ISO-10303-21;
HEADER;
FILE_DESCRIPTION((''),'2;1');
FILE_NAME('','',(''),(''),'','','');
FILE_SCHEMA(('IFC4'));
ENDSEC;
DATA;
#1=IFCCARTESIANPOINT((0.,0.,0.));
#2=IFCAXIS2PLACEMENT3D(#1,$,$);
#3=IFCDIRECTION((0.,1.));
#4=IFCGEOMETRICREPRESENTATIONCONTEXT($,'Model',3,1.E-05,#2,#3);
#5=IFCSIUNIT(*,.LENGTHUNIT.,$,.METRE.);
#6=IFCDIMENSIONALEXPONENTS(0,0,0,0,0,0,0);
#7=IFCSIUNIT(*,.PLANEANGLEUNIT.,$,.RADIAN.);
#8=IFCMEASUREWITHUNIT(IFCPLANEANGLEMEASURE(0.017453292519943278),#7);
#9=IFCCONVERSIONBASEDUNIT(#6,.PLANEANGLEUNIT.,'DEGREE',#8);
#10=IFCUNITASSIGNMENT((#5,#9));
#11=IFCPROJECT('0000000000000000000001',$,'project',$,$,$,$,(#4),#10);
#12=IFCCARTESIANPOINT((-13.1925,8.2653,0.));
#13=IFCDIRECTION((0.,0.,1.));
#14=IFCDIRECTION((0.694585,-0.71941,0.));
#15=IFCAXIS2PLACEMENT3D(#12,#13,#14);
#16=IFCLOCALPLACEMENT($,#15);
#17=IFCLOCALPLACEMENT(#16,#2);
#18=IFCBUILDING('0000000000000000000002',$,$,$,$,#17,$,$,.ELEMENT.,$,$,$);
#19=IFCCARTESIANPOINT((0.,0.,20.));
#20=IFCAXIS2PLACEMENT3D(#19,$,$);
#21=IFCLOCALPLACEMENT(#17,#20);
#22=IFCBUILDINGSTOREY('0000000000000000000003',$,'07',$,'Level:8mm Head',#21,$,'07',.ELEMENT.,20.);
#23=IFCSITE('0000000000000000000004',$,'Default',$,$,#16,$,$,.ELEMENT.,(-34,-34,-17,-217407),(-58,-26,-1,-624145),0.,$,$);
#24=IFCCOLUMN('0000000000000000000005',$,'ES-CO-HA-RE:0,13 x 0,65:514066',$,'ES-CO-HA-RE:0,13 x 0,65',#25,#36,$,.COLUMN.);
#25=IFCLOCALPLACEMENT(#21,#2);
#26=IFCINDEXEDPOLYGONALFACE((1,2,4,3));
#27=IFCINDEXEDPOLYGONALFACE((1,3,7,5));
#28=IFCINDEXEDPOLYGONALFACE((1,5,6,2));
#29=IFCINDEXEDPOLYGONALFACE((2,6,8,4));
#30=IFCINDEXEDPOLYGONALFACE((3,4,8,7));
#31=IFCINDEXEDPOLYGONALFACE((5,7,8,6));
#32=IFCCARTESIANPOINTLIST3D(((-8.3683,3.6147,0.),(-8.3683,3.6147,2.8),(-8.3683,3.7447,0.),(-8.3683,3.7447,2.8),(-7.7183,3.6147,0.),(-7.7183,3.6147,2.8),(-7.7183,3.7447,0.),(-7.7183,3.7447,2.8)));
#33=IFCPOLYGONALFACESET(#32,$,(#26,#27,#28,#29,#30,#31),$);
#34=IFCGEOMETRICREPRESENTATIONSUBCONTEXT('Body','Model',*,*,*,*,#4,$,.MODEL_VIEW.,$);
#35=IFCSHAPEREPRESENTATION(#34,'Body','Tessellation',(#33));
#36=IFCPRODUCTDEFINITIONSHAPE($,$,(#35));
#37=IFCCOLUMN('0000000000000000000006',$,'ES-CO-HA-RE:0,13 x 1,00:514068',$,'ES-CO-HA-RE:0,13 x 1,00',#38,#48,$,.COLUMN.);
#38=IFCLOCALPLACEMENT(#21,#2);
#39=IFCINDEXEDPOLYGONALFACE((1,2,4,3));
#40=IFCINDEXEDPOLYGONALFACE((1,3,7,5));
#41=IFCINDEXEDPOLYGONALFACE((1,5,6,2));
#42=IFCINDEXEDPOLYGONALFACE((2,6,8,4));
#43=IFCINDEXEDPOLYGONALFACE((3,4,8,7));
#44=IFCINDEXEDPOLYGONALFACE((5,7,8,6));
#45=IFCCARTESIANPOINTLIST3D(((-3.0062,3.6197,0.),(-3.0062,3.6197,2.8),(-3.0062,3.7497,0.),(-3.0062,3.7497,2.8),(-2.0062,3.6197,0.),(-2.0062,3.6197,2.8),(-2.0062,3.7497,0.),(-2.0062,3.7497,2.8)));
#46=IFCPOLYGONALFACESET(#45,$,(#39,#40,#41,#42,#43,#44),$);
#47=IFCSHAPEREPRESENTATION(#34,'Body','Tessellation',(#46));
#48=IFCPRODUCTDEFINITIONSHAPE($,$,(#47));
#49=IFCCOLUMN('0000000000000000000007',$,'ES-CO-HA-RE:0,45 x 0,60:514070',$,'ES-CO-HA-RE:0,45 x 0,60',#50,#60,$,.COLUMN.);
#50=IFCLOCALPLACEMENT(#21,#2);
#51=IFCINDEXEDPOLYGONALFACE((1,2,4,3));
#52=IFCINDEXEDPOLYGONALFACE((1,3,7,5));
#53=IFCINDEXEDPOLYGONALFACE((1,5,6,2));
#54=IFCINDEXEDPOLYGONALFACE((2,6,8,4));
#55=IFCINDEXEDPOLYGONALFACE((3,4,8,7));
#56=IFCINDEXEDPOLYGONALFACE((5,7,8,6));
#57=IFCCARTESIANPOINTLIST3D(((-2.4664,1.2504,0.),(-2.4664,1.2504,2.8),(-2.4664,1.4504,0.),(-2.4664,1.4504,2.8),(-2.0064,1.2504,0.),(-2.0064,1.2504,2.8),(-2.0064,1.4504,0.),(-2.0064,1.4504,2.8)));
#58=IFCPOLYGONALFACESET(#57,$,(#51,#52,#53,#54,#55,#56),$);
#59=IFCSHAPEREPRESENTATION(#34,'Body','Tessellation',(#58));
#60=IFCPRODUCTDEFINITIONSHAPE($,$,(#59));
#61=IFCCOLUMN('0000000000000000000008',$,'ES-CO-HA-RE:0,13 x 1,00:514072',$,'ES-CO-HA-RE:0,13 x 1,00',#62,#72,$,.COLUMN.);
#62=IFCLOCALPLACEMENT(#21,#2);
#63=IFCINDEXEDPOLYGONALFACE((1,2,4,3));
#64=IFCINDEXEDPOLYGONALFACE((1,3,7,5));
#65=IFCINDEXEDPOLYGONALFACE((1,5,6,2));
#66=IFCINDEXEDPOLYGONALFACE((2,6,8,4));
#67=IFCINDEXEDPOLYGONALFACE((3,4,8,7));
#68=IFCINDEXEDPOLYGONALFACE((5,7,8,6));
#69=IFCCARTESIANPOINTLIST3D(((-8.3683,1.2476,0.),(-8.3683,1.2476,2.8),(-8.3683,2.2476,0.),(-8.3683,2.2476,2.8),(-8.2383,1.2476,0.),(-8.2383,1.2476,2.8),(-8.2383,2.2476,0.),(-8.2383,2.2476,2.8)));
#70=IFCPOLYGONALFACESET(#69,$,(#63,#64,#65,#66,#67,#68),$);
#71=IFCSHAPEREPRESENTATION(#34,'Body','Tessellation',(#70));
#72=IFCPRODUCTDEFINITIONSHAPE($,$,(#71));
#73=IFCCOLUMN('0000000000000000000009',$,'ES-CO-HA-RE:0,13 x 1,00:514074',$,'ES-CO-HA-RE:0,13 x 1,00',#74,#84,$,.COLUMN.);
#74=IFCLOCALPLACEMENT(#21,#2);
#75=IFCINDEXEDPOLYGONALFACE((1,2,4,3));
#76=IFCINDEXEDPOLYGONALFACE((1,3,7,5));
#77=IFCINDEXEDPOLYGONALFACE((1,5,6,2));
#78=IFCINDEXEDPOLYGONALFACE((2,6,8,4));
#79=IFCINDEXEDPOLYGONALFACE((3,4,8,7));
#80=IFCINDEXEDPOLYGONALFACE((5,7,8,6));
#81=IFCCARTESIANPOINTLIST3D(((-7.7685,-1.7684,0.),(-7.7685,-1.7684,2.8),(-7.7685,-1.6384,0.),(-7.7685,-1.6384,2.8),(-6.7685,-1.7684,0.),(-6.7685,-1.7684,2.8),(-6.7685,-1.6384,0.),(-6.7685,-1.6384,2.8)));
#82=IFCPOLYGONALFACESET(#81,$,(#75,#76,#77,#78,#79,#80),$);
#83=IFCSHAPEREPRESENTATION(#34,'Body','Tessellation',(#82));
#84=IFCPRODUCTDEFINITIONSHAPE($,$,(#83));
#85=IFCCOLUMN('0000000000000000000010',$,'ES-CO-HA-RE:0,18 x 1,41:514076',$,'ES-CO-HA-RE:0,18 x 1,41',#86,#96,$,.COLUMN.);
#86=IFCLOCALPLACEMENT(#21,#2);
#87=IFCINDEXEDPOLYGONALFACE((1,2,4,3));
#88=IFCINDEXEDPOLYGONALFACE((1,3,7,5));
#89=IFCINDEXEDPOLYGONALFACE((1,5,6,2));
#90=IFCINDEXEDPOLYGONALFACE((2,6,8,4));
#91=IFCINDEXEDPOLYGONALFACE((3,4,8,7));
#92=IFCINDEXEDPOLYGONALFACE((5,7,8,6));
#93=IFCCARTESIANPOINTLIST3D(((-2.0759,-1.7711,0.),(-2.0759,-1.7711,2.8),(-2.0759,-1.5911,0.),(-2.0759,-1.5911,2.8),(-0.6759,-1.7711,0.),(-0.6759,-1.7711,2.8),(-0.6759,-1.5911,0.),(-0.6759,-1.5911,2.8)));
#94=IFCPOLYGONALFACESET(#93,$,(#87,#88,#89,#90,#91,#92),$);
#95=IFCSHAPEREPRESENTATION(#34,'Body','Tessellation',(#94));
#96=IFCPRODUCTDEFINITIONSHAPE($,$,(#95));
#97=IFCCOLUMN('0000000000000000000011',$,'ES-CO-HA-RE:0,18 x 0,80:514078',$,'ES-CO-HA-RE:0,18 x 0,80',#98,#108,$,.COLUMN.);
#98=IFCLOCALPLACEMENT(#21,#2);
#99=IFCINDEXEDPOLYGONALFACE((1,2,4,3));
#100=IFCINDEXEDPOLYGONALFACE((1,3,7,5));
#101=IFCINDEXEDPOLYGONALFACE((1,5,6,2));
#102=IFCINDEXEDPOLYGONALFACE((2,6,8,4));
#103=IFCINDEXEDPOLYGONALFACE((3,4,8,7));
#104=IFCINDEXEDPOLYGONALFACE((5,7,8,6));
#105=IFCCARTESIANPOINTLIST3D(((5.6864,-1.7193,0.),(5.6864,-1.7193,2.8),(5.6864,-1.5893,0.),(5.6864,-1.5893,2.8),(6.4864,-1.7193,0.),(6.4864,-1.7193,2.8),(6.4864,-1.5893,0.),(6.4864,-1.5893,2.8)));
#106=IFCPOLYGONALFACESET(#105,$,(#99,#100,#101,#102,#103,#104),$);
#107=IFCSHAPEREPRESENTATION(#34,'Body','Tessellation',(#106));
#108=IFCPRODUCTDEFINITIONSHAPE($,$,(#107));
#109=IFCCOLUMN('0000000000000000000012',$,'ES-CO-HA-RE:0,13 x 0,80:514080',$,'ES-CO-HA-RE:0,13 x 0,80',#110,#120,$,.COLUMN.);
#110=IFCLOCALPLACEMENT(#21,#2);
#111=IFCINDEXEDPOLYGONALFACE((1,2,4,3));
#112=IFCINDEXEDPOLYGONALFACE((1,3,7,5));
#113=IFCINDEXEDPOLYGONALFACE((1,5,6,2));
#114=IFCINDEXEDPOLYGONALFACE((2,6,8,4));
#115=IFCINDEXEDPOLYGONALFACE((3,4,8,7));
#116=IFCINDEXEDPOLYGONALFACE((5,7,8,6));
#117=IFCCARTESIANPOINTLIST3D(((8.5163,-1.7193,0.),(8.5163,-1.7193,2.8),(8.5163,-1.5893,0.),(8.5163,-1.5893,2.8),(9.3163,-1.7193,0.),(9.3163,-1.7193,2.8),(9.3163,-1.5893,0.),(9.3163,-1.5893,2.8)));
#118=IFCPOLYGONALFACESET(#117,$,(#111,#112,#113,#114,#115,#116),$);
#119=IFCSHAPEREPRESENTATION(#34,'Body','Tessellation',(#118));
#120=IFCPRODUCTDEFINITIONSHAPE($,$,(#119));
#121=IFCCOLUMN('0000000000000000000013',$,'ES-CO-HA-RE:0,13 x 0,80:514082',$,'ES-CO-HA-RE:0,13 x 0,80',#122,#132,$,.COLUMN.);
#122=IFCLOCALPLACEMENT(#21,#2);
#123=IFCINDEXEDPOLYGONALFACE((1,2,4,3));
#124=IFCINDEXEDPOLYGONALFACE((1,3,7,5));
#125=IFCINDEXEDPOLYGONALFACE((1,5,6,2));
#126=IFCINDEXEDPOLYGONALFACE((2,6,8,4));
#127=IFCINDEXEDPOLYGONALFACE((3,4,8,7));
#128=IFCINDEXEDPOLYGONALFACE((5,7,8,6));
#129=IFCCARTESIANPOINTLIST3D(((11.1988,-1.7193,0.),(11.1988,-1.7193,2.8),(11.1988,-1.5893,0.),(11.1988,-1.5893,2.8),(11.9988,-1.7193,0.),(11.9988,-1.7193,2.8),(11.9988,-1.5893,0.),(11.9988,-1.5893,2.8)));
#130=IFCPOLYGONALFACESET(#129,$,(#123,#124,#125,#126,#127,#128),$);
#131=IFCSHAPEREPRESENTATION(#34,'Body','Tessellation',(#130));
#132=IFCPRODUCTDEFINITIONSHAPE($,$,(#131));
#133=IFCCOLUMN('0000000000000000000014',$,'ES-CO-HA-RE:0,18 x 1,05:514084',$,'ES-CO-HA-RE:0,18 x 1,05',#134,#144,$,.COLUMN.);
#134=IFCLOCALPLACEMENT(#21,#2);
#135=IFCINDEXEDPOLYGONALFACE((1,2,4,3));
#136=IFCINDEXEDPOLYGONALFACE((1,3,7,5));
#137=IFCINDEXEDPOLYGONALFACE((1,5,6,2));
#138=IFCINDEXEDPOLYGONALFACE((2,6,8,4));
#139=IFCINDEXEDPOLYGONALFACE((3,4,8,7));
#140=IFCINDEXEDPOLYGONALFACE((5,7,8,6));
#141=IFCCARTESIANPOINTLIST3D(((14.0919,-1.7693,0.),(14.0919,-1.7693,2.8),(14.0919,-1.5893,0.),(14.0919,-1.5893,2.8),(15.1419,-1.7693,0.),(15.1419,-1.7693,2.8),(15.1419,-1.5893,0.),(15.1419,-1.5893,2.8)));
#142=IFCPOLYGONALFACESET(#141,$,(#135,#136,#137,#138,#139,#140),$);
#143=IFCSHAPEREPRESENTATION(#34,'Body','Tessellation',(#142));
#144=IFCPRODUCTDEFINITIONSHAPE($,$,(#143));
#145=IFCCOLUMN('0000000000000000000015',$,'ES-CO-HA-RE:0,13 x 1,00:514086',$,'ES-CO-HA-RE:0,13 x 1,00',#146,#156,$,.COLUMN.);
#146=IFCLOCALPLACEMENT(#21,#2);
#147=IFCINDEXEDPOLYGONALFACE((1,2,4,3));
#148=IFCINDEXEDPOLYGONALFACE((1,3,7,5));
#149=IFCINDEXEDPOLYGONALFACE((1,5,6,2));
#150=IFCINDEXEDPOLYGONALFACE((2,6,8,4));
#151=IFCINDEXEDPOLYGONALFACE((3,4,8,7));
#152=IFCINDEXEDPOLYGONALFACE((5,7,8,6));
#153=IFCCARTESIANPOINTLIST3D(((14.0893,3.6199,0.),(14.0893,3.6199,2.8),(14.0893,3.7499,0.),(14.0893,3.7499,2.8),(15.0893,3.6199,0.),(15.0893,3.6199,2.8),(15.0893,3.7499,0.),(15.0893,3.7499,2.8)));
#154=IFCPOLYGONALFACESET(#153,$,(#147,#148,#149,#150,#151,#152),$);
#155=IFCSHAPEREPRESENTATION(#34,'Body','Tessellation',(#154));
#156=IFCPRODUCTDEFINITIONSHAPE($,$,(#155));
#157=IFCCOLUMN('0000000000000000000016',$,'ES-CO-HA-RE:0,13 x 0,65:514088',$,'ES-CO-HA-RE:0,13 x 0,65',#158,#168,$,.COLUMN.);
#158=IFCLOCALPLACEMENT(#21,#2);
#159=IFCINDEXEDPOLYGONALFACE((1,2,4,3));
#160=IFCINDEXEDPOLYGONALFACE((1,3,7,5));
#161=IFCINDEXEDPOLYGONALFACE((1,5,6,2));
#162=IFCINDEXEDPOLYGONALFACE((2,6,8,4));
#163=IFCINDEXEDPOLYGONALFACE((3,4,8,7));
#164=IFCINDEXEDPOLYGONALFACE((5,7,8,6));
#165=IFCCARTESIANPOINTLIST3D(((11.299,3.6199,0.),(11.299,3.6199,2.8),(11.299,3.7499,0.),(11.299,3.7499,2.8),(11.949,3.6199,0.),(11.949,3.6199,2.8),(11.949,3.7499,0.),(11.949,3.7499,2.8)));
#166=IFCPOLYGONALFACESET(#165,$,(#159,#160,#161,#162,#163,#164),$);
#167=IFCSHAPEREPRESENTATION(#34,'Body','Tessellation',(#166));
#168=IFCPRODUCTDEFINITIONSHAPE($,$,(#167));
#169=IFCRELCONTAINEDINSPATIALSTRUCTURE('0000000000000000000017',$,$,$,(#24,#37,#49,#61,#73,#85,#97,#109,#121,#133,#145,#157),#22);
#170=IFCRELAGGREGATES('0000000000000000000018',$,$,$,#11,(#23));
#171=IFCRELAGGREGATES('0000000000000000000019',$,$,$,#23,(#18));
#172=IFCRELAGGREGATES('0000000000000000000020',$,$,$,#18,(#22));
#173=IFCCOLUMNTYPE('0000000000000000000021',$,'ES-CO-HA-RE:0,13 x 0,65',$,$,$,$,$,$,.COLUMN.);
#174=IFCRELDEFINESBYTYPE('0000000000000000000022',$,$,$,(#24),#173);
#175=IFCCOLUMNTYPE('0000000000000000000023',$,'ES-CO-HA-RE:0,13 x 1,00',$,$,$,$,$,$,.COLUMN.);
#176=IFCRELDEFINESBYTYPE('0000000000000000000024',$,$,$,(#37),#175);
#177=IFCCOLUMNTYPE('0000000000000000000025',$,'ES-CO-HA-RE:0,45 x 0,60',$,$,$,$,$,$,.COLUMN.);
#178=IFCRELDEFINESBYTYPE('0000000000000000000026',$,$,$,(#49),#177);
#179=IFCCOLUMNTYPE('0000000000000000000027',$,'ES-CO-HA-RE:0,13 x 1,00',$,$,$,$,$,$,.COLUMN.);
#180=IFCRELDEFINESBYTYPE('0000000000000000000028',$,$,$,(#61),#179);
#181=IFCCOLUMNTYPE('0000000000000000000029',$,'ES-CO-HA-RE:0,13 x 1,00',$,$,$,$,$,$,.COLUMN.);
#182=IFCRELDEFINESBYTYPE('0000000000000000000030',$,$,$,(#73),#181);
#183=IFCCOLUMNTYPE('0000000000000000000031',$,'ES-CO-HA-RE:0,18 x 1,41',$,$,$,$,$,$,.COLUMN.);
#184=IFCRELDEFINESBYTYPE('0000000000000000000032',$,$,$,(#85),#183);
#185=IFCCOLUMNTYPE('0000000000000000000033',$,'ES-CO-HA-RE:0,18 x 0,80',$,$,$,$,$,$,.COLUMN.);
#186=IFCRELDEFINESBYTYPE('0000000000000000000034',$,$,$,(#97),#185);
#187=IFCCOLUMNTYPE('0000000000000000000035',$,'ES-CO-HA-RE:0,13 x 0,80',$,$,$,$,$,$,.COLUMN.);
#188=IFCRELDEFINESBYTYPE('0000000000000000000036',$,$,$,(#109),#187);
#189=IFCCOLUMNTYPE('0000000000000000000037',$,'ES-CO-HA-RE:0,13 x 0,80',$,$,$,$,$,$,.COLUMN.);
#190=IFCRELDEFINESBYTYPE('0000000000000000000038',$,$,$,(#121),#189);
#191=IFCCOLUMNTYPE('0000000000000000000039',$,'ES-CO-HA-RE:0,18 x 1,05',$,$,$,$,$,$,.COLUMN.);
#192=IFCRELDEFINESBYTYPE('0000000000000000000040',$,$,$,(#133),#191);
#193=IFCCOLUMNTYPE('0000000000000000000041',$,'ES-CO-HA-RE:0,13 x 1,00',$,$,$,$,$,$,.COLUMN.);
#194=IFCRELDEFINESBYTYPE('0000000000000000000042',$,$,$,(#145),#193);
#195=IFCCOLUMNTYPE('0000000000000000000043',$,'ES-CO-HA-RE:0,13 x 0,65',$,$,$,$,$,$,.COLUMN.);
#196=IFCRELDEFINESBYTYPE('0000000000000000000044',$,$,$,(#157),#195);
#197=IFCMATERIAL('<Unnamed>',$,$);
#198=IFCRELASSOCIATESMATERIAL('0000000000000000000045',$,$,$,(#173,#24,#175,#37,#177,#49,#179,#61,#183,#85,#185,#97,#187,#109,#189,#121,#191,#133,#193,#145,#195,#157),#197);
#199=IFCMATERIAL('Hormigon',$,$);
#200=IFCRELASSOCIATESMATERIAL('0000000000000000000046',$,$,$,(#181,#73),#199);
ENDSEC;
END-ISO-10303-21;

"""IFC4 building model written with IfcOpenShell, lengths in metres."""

from ifc_helpers import new_model, entity, si_unit, converted_unit, direction, frame, origin, place, context, subcontext, project, spatial, indexed_curve, outline, extrude, source, transform, mapped, material, type_object, type_shapes, element, save


model = new_model("IFC4")

# Units and contexts
model_context = context("Model", 3, precision=1e-05, world=origin(), true_north=direction((0.0, 1.0)))
body_context = subcontext(model_context, "Body", "Model", "MODEL_VIEW")
ifc_project = project(units=[si_unit("LENGTHUNIT", "METRE"), converted_unit("PLANEANGLEUNIT", "DEGREE", entity("IfcPlaneAngleMeasure", 0.017453292519943278), si_unit("PLANEANGLEUNIT", "RADIAN"), dimensions=[0, 0, 0, 0, 0, 0, 0])], contexts=[model_context])

# Site, building, storey
site_placement = place(None, frame((-13.1925, 8.2653, 0.0), z_axis=(0.0, 0.0, 1.0), x_axis=(0.694585, -0.71941, 0.0)))
site = spatial("IfcSite", under=ifc_project, at=site_placement, Name="Default", CompositionType="ELEMENT", RefLatitude=(-34, -34, -17, -217407), RefLongitude=(-58, -26, -1, -624145), RefElevation=0.0)
building_placement = place(site_placement, origin())
building = spatial("IfcBuilding", under=site, at=building_placement, CompositionType="ELEMENT")
storey_placement = place(building_placement, frame((0.0, 0.0, 20.0)))
storey = spatial("IfcBuildingStorey", under=building, at=storey_placement, Name="07", ObjectType="Level:8mm Head", LongName="07", CompositionType="ELEMENT", Elevation=20.0)

# Columns
ifc_material_1 = material(Name="<Unnamed>")
column_type_1 = type_object("IfcColumnType", Name="ES-CO-HA-RE:0,13 x 0,65", PredefinedType="COLUMN", material=ifc_material_1)
shared_shape_1 = source(origin(), body_context, "Body", "SweptSolid", [
    extrude(outline(indexed_curve([(-0.325, -0.065), (0.325, -0.065), (0.325, 0.065), (-0.325, 0.065), (-0.325, -0.065)], self_intersect=False)), frame((-8.0433, 3.6797, 20.0), z_axis=(0.0, 0.0, 1.0), x_axis=(-1.0, 0.0, 0.0)), (0.0, 0.0, 1.0), 2.8),
])
type_shapes(column_type_1, [shared_shape_1])
column_1_placement = place(storey_placement, frame((0.0, 0.0, -20.0)))
element("IfcColumn", 1, at=column_1_placement, inside=storey, type_object=column_type_1, material=ifc_material_1, Name="ES-CO-HA-RE:0,13 x 0,65:514066", ObjectType="ES-CO-HA-RE:0,13 x 0,65", PredefinedType="COLUMN", context=body_context, shape_type="MappedRepresentation", body=[
    mapped(shared_shape_1, transform((0.0, 0.0, 0.0), scale=1.0)),
])
column_type_2 = type_object("IfcColumnType", Name="ES-CO-HA-RE:0,13 x 1,00", PredefinedType="COLUMN", material=ifc_material_1)
shared_shape_2 = source(origin(), body_context, "Body", "SweptSolid", [
    extrude(outline(indexed_curve([(-0.5, -0.065), (0.5, -0.065), (0.5, 0.065), (-0.5, 0.065), (-0.5, -0.065)], self_intersect=False)), frame((-2.5062, 3.6847, 20.0), z_axis=(0.0, 0.0, 1.0), x_axis=(-1.0, 0.0, 0.0)), (0.0, 0.0, 1.0), 2.8),
])
type_shapes(column_type_2, [shared_shape_2])
column_2_placement = place(storey_placement, frame((0.0, 0.0, -20.0)))
element("IfcColumn", 2, at=column_2_placement, inside=storey, type_object=column_type_2, material=ifc_material_1, Name="ES-CO-HA-RE:0,13 x 1,00:514068", ObjectType="ES-CO-HA-RE:0,13 x 1,00", PredefinedType="COLUMN", context=body_context, shape_type="MappedRepresentation", body=[
    mapped(shared_shape_2, transform((0.0, 0.0, 0.0), scale=1.0)),
])
column_type_3 = type_object("IfcColumnType", Name="ES-CO-HA-RE:0,45 x 0,60", PredefinedType="COLUMN", material=ifc_material_1)
shared_shape_3 = source(origin(), body_context, "Body", "SweptSolid", [
    extrude(outline(indexed_curve([(-0.23, -0.1), (0.23, -0.1), (0.23, 0.1), (-0.23, 0.1), (-0.23, -0.1)], self_intersect=False)), frame((-2.2364, 1.3504, 20.0), z_axis=(0.0, 0.0, 1.0), x_axis=(-1.0, 0.0, 0.0)), (0.0, 0.0, 1.0), 2.8),
])
type_shapes(column_type_3, [shared_shape_3])
column_3_placement = place(storey_placement, frame((0.0, 0.0, -20.0)))
element("IfcColumn", 3, at=column_3_placement, inside=storey, type_object=column_type_3, material=ifc_material_1, Name="ES-CO-HA-RE:0,45 x 0,60:514070", ObjectType="ES-CO-HA-RE:0,45 x 0,60", PredefinedType="COLUMN", context=body_context, shape_type="MappedRepresentation", body=[
    mapped(shared_shape_3, transform((0.0, 0.0, 0.0), scale=1.0)),
])
column_type_4 = type_object("IfcColumnType", Name="ES-CO-HA-RE:0,13 x 1,00", PredefinedType="COLUMN", material=ifc_material_1)
shared_shape_4 = source(origin(), body_context, "Body", "SweptSolid", [
    extrude(outline(indexed_curve([(-0.5, -0.065), (0.5, -0.065), (0.5, 0.065), (-0.5, 0.065), (-0.5, -0.065)], self_intersect=False)), frame((-8.3033, 1.7476, 20.0), z_axis=(0.0, 0.0, 1.0), x_axis=(0.0, -1.0, 0.0)), (0.0, 0.0, 1.0), 2.8),
])
type_shapes(column_type_4, [shared_shape_4])
column_4_placement = place(storey_placement, frame((0.0, 0.0, -20.0)))
element("IfcColumn", 4, at=column_4_placement, inside=storey, type_object=column_type_4, material=ifc_material_1, Name="ES-CO-HA-RE:0,13 x 1,00:514072", ObjectType="ES-CO-HA-RE:0,13 x 1,00", PredefinedType="COLUMN", context=body_context, shape_type="MappedRepresentation", body=[
    mapped(shared_shape_4, transform((0.0, 0.0, 0.0), scale=1.0)),
])
ifc_material_2 = material(Name="Hormigon")
column_type_5 = type_object("IfcColumnType", Name="ES-CO-HA-RE:0,13 x 1,00", PredefinedType="COLUMN", material=ifc_material_2)
shared_shape_5 = source(origin(), body_context, "Body", "SweptSolid", [
    extrude(outline(indexed_curve([(-0.5, -0.065), (0.5, -0.065), (0.5, 0.065), (-0.5, 0.065), (-0.5, -0.065)], self_intersect=False)), frame((-7.2685, -1.7034, 20.0), z_axis=(0.0, 0.0, 1.0), x_axis=(-1.0, 0.0, 0.0)), (0.0, 0.0, 1.0), 2.8),
])
type_shapes(column_type_5, [shared_shape_5])
column_5_placement = place(storey_placement, frame((0.0, 0.0, -20.0)))
element("IfcColumn", 5, at=column_5_placement, inside=storey, type_object=column_type_5, material=ifc_material_2, Name="ES-CO-HA-RE:0,13 x 1,00:514074", ObjectType="ES-CO-HA-RE:0,13 x 1,00", PredefinedType="COLUMN", context=body_context, shape_type="MappedRepresentation", body=[
    mapped(shared_shape_5, transform((0.0, 0.0, 0.0), scale=1.0)),
])
column_type_6 = type_object("IfcColumnType", Name="ES-CO-HA-RE:0,18 x 1,41", PredefinedType="COLUMN", material=ifc_material_1)
shared_shape_6 = source(origin(), body_context, "Body", "SweptSolid", [
    extrude(outline(indexed_curve([(-0.7, -0.09), (0.7, -0.09), (0.7, 0.09), (-0.7, 0.09), (-0.7, -0.09)], self_intersect=False)), frame((-1.3759, -1.6811, 20.0), z_axis=(0.0, 0.0, 1.0), x_axis=(-1.0, 0.0, 0.0)), (0.0, 0.0, 1.0), 2.8),
])
type_shapes(column_type_6, [shared_shape_6])
column_6_placement = place(storey_placement, frame((0.0, 0.0, -20.0)))
element("IfcColumn", 6, at=column_6_placement, inside=storey, type_object=column_type_6, material=ifc_material_1, Name="ES-CO-HA-RE:0,18 x 1,41:514076", ObjectType="ES-CO-HA-RE:0,18 x 1,41", PredefinedType="COLUMN", context=body_context, shape_type="MappedRepresentation", body=[
    mapped(shared_shape_6, transform((0.0, 0.0, 0.0), scale=1.0)),
])
column_type_7 = type_object("IfcColumnType", Name="ES-CO-HA-RE:0,18 x 0,80", PredefinedType="COLUMN", material=ifc_material_1)
shared_shape_7 = source(origin(), body_context, "Body", "SweptSolid", [
    extrude(outline(indexed_curve([(-0.4, -0.065), (0.4, -0.065), (0.4, 0.065), (-0.4, 0.065), (-0.4, -0.065)], self_intersect=False)), frame((6.0864, -1.6543, 20.0), z_axis=(0.0, 0.0, 1.0), x_axis=(-1.0, 0.0, 0.0)), (0.0, 0.0, 1.0), 2.8),
])
type_shapes(column_type_7, [shared_shape_7])
column_7_placement = place(storey_placement, frame((0.0, 0.0, -20.0)))
element("IfcColumn", 7, at=column_7_placement, inside=storey, type_object=column_type_7, material=ifc_material_1, Name="ES-CO-HA-RE:0,18 x 0,80:514078", ObjectType="ES-CO-HA-RE:0,18 x 0,80", PredefinedType="COLUMN", context=body_context, shape_type="MappedRepresentation", body=[
    mapped(shared_shape_7, transform((0.0, 0.0, 0.0), scale=1.0)),
])
column_type_8 = type_object("IfcColumnType", Name="ES-CO-HA-RE:0,13 x 0,80", PredefinedType="COLUMN", material=ifc_material_1)
shared_shape_8 = source(origin(), body_context, "Body", "SweptSolid", [
    extrude(outline(indexed_curve([(-0.4, -0.065), (0.4, -0.065), (0.4, 0.065), (-0.4, 0.065), (-0.4, -0.065)], self_intersect=False)), frame((8.9163, -1.6543, 20.0), z_axis=(0.0, 0.0, 1.0), x_axis=(-1.0, 0.0, 0.0)), (0.0, 0.0, 1.0), 2.8),
])
type_shapes(column_type_8, [shared_shape_8])
column_8_placement = place(storey_placement, frame((0.0, 0.0, -20.0)))
element("IfcColumn", 8, at=column_8_placement, inside=storey, type_object=column_type_8, material=ifc_material_1, Name="ES-CO-HA-RE:0,13 x 0,80:514080", ObjectType="ES-CO-HA-RE:0,13 x 0,80", PredefinedType="COLUMN", context=body_context, shape_type="MappedRepresentation", body=[
    mapped(shared_shape_8, transform((0.0, 0.0, 0.0), scale=1.0)),
])
column_type_9 = type_object("IfcColumnType", Name="ES-CO-HA-RE:0,13 x 0,80", PredefinedType="COLUMN", material=ifc_material_1)
shared_shape_9 = source(origin(), body_context, "Body", "SweptSolid", [
    extrude(outline(indexed_curve([(-0.4, -0.065), (0.4, -0.065), (0.4, 0.065), (-0.4, 0.065), (-0.4, -0.065)], self_intersect=False)), frame((11.5988, -1.6543, 20.0), z_axis=(0.0, 0.0, 1.0), x_axis=(-1.0, 0.0, 0.0)), (0.0, 0.0, 1.0), 2.8),
])
type_shapes(column_type_9, [shared_shape_9])
column_9_placement = place(storey_placement, frame((0.0, 0.0, -20.0)))
element("IfcColumn", 9, at=column_9_placement, inside=storey, type_object=column_type_9, material=ifc_material_1, Name="ES-CO-HA-RE:0,13 x 0,80:514082", ObjectType="ES-CO-HA-RE:0,13 x 0,80", PredefinedType="COLUMN", context=body_context, shape_type="MappedRepresentation", body=[
    mapped(shared_shape_9, transform((0.0, 0.0, 0.0), scale=1.0)),
])
column_type_10 = type_object("IfcColumnType", Name="ES-CO-HA-RE:0,18 x 1,05", PredefinedType="COLUMN", material=ifc_material_1)
shared_shape_10 = source(origin(), body_context, "Body", "SweptSolid", [
    extrude(outline(indexed_curve([(-0.525, -0.09), (0.525, -0.09), (0.525, 0.09), (-0.525, 0.09), (-0.525, -0.09)], self_intersect=False)), frame((14.6169, -1.6793, 20.0), z_axis=(0.0, 0.0, 1.0), x_axis=(-1.0, 0.0, 0.0)), (0.0, 0.0, 1.0), 2.8),
])
type_shapes(column_type_10, [shared_shape_10])
column_10_placement = place(storey_placement, frame((0.0, 0.0, -20.0)))
element("IfcColumn", 10, at=column_10_placement, inside=storey, type_object=column_type_10, material=ifc_material_1, Name="ES-CO-HA-RE:0,18 x 1,05:514084", ObjectType="ES-CO-HA-RE:0,18 x 1,05", PredefinedType="COLUMN", context=body_context, shape_type="MappedRepresentation", body=[
    mapped(shared_shape_10, transform((0.0, 0.0, 0.0), scale=1.0)),
])
column_type_11 = type_object("IfcColumnType", Name="ES-CO-HA-RE:0,13 x 1,00", PredefinedType="COLUMN", material=ifc_material_1)
shared_shape_11 = source(origin(), body_context, "Body", "SweptSolid", [
    extrude(outline(indexed_curve([(-0.5, -0.065), (0.5, -0.065), (0.5, 0.065), (-0.5, 0.065), (-0.5, -0.065)], self_intersect=False)), frame((14.5893, 3.6849, 20.0), z_axis=(0.0, 0.0, 1.0), x_axis=(-1.0, 0.0, 0.0)), (0.0, 0.0, 1.0), 2.8),
])
type_shapes(column_type_11, [shared_shape_11])
column_11_placement = place(storey_placement, frame((0.0, 0.0, -20.0)))
element("IfcColumn", 11, at=column_11_placement, inside=storey, type_object=column_type_11, material=ifc_material_1, Name="ES-CO-HA-RE:0,13 x 1,00:514086", ObjectType="ES-CO-HA-RE:0,13 x 1,00", PredefinedType="COLUMN", context=body_context, shape_type="MappedRepresentation", body=[
    mapped(shared_shape_11, transform((0.0, 0.0, 0.0), scale=1.0)),
])
column_type_12 = type_object("IfcColumnType", Name="ES-CO-HA-RE:0,13 x 0,65", PredefinedType="COLUMN", material=ifc_material_1)
shared_shape_12 = source(origin(), body_context, "Body", "SweptSolid", [
    extrude(outline(indexed_curve([(-0.325, -0.065), (0.325, -0.065), (0.325, 0.065), (-0.325, 0.065), (-0.325, -0.065)], self_intersect=False)), frame((11.624, 3.6849, 20.0), z_axis=(0.0, 0.0, 1.0), x_axis=(-1.0, 0.0, 0.0)), (0.0, 0.0, 1.0), 2.8),
])
type_shapes(column_type_12, [shared_shape_12])
column_12_placement = place(storey_placement, frame((0.0, 0.0, -20.0)))
element("IfcColumn", 12, at=column_12_placement, inside=storey, type_object=column_type_12, material=ifc_material_1, Name="ES-CO-HA-RE:0,13 x 0,65:514088", ObjectType="ES-CO-HA-RE:0,13 x 0,65", PredefinedType="COLUMN", context=body_context, shape_type="MappedRepresentation", body=[
    mapped(shared_shape_12, transform((0.0, 0.0, 0.0), scale=1.0)),
])

save(model, "model.ifc")
